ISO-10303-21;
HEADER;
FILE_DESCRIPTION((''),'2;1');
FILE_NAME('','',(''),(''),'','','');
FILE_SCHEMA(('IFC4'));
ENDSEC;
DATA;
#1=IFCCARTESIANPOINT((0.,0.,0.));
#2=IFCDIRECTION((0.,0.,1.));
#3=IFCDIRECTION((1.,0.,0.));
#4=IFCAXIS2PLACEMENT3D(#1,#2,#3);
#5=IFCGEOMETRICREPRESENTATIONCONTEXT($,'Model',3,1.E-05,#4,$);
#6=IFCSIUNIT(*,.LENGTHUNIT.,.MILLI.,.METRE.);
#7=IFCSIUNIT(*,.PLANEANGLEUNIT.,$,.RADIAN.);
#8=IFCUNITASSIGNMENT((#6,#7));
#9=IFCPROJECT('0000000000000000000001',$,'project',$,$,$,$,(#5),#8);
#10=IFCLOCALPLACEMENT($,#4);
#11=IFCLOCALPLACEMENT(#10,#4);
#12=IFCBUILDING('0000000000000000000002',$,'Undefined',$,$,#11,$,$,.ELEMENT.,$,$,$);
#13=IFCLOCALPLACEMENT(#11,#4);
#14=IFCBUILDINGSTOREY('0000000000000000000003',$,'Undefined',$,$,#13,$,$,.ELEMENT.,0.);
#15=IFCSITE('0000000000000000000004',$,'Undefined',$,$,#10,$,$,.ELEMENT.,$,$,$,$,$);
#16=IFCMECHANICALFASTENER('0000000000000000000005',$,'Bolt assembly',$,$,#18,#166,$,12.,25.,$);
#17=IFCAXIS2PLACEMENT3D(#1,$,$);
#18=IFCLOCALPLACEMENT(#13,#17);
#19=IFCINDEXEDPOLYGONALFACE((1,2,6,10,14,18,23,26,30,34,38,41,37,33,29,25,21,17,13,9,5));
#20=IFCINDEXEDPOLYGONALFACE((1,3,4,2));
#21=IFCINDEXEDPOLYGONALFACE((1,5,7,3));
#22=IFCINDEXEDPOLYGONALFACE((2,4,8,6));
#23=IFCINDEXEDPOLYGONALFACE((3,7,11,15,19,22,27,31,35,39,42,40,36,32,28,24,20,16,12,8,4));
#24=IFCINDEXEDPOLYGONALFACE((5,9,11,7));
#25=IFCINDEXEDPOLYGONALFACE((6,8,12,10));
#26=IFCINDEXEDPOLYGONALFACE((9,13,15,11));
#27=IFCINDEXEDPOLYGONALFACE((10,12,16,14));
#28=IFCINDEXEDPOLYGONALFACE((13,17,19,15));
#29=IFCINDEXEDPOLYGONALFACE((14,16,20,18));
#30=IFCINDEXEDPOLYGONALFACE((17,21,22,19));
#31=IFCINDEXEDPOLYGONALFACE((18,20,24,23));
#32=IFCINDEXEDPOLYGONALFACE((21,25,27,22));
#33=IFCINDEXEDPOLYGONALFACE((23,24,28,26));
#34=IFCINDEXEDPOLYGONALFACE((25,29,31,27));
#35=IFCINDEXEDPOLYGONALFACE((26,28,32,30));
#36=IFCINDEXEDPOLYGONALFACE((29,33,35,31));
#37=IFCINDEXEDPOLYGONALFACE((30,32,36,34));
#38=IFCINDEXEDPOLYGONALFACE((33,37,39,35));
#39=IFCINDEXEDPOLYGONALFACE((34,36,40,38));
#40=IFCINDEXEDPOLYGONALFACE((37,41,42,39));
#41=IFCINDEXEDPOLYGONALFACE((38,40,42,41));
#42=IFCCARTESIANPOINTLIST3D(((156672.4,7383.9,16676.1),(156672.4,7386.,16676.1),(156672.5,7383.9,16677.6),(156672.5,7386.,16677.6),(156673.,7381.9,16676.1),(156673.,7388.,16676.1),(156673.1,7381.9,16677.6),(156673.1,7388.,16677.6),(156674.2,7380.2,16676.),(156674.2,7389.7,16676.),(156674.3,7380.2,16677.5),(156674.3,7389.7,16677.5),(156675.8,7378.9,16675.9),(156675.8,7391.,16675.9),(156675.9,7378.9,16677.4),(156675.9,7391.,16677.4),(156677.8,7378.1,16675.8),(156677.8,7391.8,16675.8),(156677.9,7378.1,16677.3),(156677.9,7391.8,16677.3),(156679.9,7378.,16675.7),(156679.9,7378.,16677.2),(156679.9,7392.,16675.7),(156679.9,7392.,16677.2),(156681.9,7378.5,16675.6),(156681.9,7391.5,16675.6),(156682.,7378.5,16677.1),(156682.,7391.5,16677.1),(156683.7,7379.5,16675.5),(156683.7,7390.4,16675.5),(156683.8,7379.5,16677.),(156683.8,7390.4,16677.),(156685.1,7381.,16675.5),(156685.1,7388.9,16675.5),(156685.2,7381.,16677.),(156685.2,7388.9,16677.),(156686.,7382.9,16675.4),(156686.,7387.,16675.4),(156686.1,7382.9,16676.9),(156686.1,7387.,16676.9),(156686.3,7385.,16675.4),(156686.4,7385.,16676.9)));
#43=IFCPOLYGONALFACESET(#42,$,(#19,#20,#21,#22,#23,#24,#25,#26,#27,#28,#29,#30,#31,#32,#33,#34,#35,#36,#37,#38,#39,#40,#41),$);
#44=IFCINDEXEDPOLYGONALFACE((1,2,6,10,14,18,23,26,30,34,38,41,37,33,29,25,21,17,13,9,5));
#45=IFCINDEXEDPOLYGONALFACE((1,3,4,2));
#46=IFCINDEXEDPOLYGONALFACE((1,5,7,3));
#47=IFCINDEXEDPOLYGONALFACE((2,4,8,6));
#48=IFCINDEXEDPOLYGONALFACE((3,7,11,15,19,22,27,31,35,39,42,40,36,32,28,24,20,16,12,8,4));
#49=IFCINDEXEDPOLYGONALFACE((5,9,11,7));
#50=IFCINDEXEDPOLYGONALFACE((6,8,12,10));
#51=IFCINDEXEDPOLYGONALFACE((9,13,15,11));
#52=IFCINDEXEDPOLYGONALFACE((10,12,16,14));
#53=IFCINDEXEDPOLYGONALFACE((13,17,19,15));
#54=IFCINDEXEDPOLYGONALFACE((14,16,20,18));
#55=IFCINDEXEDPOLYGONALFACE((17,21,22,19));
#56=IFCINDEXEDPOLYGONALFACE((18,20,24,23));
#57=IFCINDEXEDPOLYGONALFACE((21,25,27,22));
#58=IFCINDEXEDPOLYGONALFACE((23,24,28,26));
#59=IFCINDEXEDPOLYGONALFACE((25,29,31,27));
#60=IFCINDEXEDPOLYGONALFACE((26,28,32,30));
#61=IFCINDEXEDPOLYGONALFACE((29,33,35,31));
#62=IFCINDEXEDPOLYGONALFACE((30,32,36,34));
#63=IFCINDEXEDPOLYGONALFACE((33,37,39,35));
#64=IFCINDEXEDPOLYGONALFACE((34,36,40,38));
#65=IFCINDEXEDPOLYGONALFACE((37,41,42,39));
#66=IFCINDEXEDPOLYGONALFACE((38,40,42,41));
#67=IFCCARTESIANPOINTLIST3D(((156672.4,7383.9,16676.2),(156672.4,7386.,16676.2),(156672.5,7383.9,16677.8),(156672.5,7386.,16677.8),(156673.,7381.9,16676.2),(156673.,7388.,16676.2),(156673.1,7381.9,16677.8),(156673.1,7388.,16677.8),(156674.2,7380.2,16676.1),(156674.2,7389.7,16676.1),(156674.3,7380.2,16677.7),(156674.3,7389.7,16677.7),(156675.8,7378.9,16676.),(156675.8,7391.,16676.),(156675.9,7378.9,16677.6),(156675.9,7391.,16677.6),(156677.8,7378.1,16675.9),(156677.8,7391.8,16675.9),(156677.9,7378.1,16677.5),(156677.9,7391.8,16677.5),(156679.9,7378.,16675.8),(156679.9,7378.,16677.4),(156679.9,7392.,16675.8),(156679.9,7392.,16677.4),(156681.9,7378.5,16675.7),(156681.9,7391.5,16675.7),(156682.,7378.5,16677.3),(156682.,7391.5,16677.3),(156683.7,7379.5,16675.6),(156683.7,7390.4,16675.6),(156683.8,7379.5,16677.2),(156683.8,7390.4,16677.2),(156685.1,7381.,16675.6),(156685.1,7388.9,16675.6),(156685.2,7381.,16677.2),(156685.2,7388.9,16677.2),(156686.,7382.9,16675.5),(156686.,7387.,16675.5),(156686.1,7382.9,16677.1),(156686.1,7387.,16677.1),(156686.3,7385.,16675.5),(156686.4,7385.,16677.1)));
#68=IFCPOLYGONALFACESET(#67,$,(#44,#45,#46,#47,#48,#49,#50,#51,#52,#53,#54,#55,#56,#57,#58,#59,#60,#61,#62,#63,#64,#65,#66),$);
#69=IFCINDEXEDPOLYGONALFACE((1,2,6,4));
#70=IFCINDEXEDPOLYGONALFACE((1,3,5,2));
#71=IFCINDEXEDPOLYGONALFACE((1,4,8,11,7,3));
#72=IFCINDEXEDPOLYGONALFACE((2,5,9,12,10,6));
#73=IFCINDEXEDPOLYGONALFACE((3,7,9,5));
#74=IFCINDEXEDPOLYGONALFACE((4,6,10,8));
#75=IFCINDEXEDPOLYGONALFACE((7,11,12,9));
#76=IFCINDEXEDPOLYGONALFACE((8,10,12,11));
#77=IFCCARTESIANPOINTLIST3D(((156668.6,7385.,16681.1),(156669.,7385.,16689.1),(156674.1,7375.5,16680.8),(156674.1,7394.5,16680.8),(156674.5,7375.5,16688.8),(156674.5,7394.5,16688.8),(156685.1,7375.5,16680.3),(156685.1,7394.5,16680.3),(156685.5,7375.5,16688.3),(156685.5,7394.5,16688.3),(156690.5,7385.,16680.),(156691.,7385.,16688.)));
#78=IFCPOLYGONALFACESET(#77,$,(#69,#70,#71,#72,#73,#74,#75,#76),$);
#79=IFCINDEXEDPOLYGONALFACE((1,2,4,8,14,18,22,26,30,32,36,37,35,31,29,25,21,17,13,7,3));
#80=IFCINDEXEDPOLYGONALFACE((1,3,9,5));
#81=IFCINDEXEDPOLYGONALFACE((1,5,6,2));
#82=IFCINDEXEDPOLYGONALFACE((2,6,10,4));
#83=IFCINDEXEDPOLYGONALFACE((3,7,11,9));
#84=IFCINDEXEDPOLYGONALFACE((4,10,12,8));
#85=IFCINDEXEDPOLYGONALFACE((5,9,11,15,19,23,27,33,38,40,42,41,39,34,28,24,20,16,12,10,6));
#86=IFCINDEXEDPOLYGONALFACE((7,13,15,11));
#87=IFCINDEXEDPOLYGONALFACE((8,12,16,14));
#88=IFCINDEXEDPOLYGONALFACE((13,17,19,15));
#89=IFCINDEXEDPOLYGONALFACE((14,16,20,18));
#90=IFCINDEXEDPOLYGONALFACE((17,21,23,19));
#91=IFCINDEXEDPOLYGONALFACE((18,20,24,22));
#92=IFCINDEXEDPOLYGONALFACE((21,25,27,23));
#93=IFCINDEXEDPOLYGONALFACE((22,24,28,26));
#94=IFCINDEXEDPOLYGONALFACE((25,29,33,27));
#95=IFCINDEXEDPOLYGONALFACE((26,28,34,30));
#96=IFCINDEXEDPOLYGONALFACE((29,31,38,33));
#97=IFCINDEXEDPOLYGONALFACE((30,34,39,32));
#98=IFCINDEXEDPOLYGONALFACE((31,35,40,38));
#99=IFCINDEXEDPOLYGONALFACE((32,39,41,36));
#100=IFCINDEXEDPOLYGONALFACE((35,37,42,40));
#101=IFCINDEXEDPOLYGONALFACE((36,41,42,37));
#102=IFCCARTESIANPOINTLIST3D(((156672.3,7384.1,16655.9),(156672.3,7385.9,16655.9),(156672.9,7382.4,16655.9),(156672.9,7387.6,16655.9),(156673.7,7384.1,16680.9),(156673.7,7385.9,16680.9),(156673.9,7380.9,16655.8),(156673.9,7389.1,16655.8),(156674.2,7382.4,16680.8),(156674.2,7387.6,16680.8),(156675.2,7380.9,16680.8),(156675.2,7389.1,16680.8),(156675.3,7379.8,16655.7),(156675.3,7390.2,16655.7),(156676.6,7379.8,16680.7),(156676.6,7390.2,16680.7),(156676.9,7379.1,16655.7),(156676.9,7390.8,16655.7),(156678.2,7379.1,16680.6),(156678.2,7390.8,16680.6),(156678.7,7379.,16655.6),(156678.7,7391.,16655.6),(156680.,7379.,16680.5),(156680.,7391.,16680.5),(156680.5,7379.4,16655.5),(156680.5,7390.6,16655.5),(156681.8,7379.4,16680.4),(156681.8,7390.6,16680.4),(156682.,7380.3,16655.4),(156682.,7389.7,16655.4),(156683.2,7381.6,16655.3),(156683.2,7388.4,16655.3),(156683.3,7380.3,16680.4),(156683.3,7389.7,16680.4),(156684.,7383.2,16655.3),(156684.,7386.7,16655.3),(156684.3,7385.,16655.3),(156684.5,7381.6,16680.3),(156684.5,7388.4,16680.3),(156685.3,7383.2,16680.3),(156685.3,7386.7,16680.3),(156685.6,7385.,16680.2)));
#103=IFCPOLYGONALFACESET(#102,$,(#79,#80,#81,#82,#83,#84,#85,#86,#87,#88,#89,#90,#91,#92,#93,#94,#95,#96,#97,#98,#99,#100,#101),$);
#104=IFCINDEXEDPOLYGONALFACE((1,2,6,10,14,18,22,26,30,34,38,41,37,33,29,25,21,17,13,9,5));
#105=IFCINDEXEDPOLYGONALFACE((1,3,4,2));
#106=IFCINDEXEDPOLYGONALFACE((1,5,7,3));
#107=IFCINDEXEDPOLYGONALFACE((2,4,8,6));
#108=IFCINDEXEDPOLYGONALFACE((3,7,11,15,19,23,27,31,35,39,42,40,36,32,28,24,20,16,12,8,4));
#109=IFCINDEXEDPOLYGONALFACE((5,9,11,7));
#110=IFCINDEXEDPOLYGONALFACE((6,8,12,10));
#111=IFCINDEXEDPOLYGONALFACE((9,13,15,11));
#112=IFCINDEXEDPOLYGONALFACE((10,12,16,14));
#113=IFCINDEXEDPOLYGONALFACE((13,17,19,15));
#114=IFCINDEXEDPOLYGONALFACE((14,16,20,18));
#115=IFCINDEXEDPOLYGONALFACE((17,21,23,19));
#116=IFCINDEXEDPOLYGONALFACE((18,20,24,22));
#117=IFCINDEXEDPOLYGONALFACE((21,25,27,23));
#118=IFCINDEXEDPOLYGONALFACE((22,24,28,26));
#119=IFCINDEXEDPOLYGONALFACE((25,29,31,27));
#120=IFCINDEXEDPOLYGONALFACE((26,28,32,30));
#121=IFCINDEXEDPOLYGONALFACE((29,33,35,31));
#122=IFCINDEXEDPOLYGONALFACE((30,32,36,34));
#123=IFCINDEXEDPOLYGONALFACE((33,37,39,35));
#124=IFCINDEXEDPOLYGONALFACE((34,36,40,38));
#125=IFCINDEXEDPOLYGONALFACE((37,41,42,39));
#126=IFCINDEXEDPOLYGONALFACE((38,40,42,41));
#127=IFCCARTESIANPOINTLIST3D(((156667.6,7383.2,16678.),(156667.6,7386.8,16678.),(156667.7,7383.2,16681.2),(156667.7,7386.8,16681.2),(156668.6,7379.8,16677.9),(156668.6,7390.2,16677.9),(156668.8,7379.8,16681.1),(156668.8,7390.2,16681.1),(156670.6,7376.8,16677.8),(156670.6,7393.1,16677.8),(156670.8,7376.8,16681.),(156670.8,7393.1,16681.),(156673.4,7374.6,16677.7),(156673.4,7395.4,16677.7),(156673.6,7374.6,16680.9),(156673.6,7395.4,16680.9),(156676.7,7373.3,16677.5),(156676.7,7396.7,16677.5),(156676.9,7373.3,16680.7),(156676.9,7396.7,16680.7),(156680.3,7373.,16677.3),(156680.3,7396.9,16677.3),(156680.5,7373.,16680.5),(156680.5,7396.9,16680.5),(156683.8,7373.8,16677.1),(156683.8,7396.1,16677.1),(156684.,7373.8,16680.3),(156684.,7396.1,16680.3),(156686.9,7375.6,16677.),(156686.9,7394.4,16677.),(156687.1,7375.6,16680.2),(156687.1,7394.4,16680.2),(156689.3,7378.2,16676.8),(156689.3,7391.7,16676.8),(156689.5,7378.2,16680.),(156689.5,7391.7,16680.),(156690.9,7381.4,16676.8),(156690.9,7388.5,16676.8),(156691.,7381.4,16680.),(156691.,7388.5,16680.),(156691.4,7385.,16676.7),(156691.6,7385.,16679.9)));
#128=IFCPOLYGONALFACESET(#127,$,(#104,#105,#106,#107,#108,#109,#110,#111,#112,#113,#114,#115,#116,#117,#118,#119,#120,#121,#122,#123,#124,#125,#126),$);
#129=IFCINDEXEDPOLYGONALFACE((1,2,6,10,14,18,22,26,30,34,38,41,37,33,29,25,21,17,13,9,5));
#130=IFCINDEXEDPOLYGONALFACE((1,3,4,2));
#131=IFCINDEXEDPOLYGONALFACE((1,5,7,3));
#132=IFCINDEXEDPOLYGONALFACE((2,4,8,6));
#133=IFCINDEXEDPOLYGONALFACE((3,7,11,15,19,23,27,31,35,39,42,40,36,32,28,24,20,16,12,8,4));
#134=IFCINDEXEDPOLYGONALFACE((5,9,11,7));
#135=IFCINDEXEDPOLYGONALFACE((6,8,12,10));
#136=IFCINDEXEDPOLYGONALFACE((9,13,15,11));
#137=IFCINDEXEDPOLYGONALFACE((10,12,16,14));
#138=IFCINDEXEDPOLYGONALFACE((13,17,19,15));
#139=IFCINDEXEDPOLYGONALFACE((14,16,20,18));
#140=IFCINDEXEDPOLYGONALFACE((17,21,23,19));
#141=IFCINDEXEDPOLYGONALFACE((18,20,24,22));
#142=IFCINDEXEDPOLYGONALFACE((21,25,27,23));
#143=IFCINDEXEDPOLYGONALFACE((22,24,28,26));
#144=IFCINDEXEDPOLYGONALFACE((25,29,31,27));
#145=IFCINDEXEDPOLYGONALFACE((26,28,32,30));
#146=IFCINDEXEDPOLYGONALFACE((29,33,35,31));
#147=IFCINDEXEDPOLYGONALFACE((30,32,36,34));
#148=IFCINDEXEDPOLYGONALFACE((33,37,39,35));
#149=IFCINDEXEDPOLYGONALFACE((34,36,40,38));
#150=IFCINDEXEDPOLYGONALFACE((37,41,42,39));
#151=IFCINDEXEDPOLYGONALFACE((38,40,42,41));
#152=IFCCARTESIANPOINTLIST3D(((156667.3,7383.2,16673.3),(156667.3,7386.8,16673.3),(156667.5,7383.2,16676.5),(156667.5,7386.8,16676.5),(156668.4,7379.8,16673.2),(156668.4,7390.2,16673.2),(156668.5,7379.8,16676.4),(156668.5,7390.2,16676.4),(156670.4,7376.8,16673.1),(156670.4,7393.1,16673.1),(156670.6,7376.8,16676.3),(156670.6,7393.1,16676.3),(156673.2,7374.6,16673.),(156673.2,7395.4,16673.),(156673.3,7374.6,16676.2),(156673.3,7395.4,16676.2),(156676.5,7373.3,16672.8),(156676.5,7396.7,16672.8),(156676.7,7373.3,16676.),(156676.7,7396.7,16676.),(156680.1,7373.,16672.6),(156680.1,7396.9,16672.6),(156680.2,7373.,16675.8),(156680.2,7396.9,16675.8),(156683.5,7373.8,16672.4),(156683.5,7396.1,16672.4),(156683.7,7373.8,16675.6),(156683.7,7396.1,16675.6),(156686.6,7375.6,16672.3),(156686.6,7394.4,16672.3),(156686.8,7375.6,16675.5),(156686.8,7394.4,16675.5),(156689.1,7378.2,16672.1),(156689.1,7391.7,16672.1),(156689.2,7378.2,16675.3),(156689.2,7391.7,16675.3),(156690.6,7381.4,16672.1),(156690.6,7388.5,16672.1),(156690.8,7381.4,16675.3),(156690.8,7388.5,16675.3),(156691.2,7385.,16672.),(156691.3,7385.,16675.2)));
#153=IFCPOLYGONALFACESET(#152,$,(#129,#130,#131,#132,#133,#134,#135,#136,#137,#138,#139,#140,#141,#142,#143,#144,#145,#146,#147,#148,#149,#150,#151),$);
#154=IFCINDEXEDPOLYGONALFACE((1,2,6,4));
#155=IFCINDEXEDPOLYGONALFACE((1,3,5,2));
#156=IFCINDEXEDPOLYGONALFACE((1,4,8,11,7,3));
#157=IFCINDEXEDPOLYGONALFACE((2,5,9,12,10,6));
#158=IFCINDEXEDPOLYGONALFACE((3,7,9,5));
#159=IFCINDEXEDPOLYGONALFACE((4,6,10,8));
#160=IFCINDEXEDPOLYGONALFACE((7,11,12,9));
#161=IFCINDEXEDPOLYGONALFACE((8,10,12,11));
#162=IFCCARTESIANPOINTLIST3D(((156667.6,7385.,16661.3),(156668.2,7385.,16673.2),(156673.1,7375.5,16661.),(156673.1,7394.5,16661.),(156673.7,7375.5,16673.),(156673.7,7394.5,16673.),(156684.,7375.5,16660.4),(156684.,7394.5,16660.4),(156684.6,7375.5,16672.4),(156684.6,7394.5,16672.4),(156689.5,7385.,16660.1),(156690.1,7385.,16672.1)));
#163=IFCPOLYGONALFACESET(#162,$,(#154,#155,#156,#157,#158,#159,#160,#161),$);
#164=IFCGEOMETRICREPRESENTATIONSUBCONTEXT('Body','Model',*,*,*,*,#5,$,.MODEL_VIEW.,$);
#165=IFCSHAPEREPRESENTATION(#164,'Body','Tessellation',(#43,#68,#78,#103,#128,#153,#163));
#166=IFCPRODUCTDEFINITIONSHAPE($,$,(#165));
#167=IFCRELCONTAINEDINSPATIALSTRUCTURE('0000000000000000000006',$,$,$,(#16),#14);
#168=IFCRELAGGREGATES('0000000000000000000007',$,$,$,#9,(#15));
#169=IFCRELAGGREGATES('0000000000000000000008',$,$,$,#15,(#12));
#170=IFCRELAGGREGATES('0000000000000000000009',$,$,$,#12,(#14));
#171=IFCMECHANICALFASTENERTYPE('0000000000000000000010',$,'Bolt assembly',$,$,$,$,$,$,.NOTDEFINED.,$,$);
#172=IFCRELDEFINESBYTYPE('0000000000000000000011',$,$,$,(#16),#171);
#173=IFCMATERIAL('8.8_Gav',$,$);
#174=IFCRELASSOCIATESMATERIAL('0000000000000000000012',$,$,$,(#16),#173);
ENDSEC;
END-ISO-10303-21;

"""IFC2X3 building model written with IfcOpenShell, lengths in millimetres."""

from ifc_helpers import new_model, si_unit, frame, origin_with_axes, origin_2d_with_axis, place, context, subcontext, project, spatial, polyline, circle, outline, extrude, source, transform, mapped, material, type_object, element, save


model = new_model("IFC2X3")

# Units and contexts
model_context = context("Model", 3, precision=1e-05, world=origin_with_axes())
body_context = subcontext(model_context, "Body", "Model", "MODEL_VIEW")
ifc_project = project(units=[si_unit("LENGTHUNIT", "METRE", prefix="MILLI"), si_unit("PLANEANGLEUNIT", "RADIAN")], contexts=[model_context])

# Site, building, storey
site_placement = place(None, origin_with_axes())
site = spatial("IfcSite", under=ifc_project, at=site_placement, Name="Undefined", CompositionType="ELEMENT")
building_placement = place(site_placement, origin_with_axes())
building = spatial("IfcBuilding", under=site, at=building_placement, Name="Undefined", CompositionType="ELEMENT")
storey_placement = place(building_placement, origin_with_axes())
storey = spatial("IfcBuildingStorey", under=building, at=storey_placement, Name="Undefined", CompositionType="ELEMENT", Elevation=0.0)

# Mechanical fastener
mechanical_fastener_type = type_object("IfcMechanicalFastenerType", Name="Bolt assembly")
ifc_material_1 = material(Name="8.8_Gav")
shared_shape_1 = source(origin_with_axes(), body_context, "Body", "SweptSolid", [
    extrude(circle(Radius=7.0, at=origin_2d_with_axis()), frame((0.0, -0.4, 0.0), z_axis=(0.0, 1.0, 0.0), x_axis=(1.0, 0.0, 0.0)), (0.0, 0.0, 1.0), 1.5),
    extrude(circle(Radius=7.0, at=origin_2d_with_axis()), frame((0.0, -0.6, 0.0), z_axis=(0.0, 1.0, 0.0), x_axis=(1.0, 0.0, 0.0)), (0.0, 0.0, 1.0), 1.6),
    extrude(outline(polyline([(11.0, 0.0), (5.5, 9.5), (-5.5, 9.5), (-11.0, 0.0), (-5.5, -9.5), (5.5, -9.5), (11.0, 0.0)])), frame((0.0, -11.7, 0.0), z_axis=(0.0, 1.0, 0.0), x_axis=(1.0, 0.0, 0.0)), (0.0, 0.0, 1.0), 8.0),
    extrude(circle(Radius=6.0, at=origin_2d_with_axis()), frame((0.0, -3.7, 0.0), z_axis=(0.0, 1.0, 0.0), x_axis=(1.0, 0.0, 0.0)), (0.0, 0.0, 1.0), 25.0),
    extrude(circle(Radius=12.0, at=origin_2d_with_axis()), frame((0.0, -3.7, 0.0), z_axis=(0.0, 1.0, 0.0), x_axis=(1.0, 0.0, 0.0)), (0.0, 0.0, 1.0), 3.2),
    extrude(circle(Radius=12.0, at=origin_2d_with_axis()), frame((0.0, 1.0, 0.0), z_axis=(0.0, 1.0, 0.0), x_axis=(1.0, 0.0, 0.0)), (0.0, 0.0, 1.0), 3.2),
    extrude(outline(polyline([(11.0, 0.0), (5.5, 9.5), (-5.5, 9.5), (-11.0, 0.0), (-5.5, -9.5), (5.5, -9.5), (11.0, 0.0)])), frame((0.0, 4.2, 0.0), z_axis=(0.0, 1.0, 0.0), x_axis=(1.0, 0.0, 0.0)), (0.0, 0.0, 1.0), 12.0),
])
for number, where, z_axis, x_axis, name in (
    (1, (156679.4, 7385.0, 16676.9), (0.0, 1.0, 0.0), (0.998627, 0.0, -0.052392), "Bolt assembly"),
):
    element("IfcMechanicalFastener", number, at=place(storey_placement, frame(where, z_axis=z_axis, x_axis=x_axis)), inside=storey, type_object=mechanical_fastener_type, material=ifc_material_1, Name=name, NominalDiameter=12.0, NominalLength=25.0, context=body_context, shape_type="MappedRepresentation", body=[
        mapped(shared_shape_1, transform((0.0, 0.0, 0.0))),
    ])

save(model, "model.ifc")
